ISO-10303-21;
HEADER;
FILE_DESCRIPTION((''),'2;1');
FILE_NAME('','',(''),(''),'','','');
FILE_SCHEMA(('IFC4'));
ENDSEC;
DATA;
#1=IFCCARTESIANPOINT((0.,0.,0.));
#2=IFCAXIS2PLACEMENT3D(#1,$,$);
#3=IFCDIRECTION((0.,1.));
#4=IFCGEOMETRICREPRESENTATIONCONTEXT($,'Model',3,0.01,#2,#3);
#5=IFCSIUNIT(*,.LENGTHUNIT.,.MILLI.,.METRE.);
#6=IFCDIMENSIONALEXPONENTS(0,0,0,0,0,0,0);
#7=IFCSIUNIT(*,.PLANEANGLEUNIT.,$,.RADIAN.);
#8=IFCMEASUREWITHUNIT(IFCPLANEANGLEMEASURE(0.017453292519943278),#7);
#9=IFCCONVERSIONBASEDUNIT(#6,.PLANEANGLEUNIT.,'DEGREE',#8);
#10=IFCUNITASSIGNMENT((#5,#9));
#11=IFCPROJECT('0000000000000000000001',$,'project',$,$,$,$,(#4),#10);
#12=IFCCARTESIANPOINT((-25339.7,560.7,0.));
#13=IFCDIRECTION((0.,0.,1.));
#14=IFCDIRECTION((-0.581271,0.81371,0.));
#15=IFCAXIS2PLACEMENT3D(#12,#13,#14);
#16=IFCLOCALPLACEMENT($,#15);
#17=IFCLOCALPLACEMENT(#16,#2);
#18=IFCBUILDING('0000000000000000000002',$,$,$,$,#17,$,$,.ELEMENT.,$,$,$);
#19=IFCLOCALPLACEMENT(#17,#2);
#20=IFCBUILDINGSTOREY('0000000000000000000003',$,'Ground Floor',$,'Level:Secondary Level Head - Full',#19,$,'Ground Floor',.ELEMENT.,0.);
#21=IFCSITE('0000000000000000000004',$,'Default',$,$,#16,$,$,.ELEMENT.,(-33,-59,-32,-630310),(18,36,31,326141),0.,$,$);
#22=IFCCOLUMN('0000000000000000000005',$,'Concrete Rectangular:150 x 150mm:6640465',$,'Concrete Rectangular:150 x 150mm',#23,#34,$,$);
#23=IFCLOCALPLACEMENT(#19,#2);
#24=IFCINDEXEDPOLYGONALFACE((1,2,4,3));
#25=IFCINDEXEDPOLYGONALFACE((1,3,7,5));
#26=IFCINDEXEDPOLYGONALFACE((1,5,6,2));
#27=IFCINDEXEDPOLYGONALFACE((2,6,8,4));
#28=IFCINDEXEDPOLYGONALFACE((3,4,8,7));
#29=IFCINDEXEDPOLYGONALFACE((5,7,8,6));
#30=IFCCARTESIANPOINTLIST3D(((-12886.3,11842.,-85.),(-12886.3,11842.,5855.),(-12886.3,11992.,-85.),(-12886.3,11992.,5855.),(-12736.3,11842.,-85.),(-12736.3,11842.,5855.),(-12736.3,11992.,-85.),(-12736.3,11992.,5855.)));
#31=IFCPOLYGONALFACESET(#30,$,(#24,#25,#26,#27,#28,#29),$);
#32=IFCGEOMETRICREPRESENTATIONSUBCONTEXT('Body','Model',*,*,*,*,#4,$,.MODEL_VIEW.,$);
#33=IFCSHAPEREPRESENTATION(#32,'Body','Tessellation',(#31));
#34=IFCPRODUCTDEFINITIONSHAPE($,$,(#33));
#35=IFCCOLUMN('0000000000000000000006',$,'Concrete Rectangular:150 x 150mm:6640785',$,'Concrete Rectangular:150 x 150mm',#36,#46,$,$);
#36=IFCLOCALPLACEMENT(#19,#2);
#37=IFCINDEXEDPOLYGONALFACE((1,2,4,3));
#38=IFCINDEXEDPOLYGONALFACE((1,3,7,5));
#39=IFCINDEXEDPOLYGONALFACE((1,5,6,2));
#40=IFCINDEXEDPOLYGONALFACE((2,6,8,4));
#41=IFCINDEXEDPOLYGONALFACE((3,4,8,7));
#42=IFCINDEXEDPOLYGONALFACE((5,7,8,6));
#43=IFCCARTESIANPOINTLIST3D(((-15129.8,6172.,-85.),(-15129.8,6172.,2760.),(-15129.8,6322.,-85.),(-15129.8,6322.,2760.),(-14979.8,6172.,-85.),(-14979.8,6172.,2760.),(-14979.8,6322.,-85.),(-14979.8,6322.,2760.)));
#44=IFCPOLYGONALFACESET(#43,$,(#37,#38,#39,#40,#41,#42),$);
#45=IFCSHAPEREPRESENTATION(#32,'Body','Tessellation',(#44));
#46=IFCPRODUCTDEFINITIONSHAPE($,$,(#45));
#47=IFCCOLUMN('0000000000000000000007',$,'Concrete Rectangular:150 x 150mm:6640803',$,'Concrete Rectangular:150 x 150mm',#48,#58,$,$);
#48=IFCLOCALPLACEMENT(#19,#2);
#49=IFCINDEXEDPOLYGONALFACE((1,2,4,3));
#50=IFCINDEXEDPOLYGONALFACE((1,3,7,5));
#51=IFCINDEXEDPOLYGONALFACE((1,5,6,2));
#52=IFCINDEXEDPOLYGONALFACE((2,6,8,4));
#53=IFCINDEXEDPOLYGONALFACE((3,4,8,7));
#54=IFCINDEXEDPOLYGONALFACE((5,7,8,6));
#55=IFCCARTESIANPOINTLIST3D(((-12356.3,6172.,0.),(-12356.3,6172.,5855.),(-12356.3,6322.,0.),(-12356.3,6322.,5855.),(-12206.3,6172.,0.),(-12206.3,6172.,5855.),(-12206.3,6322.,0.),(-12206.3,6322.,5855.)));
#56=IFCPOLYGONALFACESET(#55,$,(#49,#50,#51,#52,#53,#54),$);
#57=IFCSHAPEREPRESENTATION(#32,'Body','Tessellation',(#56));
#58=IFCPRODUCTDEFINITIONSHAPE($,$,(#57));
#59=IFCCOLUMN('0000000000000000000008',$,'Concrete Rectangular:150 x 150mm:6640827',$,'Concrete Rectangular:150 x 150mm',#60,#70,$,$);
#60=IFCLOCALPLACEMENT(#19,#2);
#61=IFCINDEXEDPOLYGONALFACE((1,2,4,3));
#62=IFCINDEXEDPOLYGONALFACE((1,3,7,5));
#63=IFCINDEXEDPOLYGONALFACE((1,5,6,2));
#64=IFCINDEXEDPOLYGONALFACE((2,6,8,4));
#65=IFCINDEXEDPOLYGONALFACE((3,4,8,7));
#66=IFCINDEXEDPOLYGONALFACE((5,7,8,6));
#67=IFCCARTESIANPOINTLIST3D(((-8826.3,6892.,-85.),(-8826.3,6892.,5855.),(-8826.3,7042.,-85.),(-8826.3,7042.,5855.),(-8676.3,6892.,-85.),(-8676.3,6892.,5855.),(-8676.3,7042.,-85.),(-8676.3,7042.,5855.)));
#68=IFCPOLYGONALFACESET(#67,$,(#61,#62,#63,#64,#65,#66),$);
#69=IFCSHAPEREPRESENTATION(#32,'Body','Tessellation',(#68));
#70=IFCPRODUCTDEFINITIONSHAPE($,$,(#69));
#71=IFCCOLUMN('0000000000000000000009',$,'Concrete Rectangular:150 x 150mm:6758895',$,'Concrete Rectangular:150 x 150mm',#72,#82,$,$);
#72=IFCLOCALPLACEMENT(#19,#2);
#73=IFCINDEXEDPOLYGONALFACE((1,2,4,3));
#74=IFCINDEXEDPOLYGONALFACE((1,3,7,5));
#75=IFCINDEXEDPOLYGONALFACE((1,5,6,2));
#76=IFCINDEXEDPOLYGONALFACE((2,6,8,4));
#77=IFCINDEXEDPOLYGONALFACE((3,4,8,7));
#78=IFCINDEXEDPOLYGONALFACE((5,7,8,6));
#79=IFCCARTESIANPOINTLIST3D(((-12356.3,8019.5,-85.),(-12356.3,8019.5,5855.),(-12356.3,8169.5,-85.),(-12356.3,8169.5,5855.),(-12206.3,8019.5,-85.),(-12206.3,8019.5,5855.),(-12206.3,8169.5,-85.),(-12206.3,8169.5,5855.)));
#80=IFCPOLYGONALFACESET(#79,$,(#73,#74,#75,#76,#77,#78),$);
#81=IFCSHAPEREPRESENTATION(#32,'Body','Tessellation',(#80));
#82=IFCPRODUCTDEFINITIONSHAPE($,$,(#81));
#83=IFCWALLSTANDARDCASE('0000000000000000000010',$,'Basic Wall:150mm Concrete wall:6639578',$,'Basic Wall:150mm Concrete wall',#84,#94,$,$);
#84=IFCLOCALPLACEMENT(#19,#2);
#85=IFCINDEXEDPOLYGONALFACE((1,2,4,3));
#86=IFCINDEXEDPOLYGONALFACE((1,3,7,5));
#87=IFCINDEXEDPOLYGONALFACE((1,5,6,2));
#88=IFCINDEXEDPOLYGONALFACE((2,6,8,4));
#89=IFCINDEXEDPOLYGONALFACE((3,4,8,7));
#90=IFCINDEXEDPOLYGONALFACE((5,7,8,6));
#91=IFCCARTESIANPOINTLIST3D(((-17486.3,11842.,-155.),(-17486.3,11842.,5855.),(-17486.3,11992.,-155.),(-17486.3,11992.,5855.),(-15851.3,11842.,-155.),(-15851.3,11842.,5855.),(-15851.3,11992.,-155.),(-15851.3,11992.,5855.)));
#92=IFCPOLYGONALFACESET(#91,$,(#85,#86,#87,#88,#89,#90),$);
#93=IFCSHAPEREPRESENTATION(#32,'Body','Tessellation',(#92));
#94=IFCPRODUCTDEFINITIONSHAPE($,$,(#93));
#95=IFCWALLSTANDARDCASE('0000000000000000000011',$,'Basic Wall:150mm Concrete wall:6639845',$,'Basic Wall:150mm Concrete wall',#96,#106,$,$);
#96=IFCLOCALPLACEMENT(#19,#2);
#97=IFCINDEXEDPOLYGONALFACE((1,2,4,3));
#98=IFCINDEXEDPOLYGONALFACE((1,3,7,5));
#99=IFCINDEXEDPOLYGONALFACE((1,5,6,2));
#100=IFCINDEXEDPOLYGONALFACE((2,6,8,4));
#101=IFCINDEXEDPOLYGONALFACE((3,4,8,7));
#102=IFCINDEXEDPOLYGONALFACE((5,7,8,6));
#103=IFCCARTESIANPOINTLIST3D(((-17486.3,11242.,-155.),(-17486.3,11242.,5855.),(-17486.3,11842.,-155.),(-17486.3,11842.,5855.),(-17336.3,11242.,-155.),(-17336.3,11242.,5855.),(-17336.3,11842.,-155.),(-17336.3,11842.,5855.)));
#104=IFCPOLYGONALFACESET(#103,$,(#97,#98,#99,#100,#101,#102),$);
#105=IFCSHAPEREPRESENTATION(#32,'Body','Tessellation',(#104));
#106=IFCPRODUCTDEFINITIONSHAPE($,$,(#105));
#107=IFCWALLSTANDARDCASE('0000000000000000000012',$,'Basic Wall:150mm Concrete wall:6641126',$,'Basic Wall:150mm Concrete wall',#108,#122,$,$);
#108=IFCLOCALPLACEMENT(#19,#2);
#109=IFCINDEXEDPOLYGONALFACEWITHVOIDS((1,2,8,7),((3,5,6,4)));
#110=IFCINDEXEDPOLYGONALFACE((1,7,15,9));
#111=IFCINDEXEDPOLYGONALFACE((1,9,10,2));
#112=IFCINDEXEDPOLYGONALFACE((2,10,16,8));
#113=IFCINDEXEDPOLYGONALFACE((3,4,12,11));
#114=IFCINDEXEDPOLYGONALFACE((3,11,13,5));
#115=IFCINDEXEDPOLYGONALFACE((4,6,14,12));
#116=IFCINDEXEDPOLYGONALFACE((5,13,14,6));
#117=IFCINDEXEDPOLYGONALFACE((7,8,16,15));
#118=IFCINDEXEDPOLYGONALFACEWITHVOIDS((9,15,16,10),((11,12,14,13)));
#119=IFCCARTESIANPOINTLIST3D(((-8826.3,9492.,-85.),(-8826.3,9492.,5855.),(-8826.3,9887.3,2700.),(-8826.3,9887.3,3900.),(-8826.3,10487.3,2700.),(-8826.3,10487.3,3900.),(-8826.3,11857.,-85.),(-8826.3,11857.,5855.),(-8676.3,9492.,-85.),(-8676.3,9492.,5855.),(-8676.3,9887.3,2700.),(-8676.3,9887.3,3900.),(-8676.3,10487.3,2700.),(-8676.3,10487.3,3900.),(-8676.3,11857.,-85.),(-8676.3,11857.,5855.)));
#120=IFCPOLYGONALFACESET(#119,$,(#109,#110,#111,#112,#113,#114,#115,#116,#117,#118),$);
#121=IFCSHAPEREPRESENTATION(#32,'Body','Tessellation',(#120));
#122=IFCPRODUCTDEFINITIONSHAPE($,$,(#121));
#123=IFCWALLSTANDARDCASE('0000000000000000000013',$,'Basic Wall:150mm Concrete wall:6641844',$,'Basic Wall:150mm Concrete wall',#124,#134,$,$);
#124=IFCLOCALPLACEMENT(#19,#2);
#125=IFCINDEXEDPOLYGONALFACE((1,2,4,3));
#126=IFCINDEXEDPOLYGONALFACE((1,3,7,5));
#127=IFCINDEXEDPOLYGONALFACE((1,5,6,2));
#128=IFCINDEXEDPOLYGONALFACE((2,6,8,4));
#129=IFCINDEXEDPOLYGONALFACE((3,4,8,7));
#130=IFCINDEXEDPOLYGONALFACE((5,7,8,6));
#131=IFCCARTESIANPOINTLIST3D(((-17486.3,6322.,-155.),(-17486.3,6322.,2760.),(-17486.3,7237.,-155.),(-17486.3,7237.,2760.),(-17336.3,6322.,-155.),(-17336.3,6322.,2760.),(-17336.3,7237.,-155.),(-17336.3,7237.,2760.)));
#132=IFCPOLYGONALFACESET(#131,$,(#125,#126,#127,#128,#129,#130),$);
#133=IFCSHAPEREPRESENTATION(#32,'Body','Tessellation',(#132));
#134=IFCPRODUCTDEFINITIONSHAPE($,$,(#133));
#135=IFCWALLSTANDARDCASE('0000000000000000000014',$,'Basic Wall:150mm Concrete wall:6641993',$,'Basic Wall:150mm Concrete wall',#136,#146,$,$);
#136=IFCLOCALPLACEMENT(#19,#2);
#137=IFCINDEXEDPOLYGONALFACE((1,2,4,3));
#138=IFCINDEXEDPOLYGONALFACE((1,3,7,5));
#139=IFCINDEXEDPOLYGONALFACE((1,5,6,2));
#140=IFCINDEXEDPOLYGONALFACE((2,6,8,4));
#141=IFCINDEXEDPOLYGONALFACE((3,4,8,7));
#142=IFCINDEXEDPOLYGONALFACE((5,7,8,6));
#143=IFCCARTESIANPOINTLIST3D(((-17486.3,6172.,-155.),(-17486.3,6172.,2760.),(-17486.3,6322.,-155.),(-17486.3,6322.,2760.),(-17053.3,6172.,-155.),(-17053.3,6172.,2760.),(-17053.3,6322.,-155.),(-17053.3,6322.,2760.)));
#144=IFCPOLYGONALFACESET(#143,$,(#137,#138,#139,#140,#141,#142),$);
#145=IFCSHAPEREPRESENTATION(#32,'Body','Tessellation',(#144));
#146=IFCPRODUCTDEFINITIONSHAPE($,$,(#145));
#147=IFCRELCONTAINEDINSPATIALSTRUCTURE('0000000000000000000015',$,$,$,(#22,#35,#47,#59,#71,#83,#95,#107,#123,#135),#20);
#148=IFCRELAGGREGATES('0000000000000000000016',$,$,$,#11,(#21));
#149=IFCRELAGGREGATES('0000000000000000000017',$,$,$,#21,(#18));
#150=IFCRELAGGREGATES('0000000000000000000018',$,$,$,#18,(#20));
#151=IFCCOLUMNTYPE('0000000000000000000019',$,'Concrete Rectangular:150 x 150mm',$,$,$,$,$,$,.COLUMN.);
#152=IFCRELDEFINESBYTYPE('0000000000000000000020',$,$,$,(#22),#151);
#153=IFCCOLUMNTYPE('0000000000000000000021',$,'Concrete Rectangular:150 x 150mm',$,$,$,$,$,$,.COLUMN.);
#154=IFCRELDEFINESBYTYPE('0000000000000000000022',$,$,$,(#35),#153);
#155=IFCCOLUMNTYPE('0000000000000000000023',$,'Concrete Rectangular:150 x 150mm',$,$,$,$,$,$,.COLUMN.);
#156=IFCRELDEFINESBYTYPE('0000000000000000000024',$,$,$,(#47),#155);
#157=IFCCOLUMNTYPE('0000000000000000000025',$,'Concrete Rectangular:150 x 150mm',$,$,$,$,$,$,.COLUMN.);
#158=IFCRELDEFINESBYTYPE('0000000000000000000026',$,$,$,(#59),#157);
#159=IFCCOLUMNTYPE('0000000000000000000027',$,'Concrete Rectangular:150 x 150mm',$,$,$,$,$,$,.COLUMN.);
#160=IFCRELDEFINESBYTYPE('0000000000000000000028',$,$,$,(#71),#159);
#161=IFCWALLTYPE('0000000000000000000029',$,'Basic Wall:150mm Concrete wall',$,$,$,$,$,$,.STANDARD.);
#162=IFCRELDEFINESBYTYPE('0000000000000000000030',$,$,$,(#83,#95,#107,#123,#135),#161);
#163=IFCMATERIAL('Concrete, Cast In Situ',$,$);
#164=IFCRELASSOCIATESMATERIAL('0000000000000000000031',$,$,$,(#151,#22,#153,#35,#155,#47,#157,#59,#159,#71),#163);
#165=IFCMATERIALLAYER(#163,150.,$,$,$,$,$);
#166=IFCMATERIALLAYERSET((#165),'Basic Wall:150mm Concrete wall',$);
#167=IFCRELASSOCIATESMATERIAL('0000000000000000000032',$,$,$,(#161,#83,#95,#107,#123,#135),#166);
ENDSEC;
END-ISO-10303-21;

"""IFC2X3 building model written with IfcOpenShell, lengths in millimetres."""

from ifc_helpers import new_model, entity, si_unit, converted_unit, direction, frame, frame_2d, origin, origin_2d_with_axis, place, context, subcontext, project, spatial, polyline, rectangle, extrude, clip, bounded_halfspace, source, transform, mapped, material, layer, layer_set, layer_usage, type_object, type_shapes, element, save


model = new_model("IFC2X3")

# Units and contexts
model_context = context("Model", 3, precision=0.01, world=origin(), true_north=direction((0.0, 1.0)))
body_context = subcontext(model_context, "Body", "Model", "MODEL_VIEW")
ifc_project = project(units=[si_unit("LENGTHUNIT", "METRE", prefix="MILLI"), converted_unit("PLANEANGLEUNIT", "DEGREE", entity("IfcPlaneAngleMeasure", 0.017453292519943278), si_unit("PLANEANGLEUNIT", "RADIAN"), dimensions=[0, 0, 0, 0, 0, 0, 0])], contexts=[model_context])

# Site, building, storey
site_placement = place(None, frame((-25339.7, 560.7, 0.0), z_axis=(0.0, 0.0, 1.0), x_axis=(-0.581271, 0.81371, 0.0)))
site = spatial("IfcSite", under=ifc_project, at=site_placement, Name="Default", CompositionType="ELEMENT", RefLatitude=(-33, -59, -32, -630310), RefLongitude=(18, 36, 31, 326141), RefElevation=0.0)
building_placement = place(site_placement, origin())
building = spatial("IfcBuilding", under=site, at=building_placement, CompositionType="ELEMENT")
storey_placement = place(building_placement, origin())
storey = spatial("IfcBuildingStorey", under=building, at=storey_placement, Name="Ground Floor", ObjectType="Level:Secondary Level Head - Full", LongName="Ground Floor", CompositionType="ELEMENT", Elevation=0.0)

# Columns
ifc_material = material(Name="Concrete, Cast In Situ")
column_type_1 = type_object("IfcColumnType", Name="Concrete Rectangular:150 x 150mm", PredefinedType="COLUMN", material=ifc_material)
shared_shape_1 = source(origin(), body_context, "Body", "SweptSolid", [
    extrude(rectangle(XDim=150.0, YDim=150.0, at=origin_2d_with_axis()), frame((-12811.3, 11917.0, -85.0), z_axis=(0.0, 0.0, 1.0), x_axis=(-1.0, 0.0, 0.0)), (0.0, 0.0, 1.0), 5940.0),
])
type_shapes(column_type_1, [shared_shape_1])
column_1_placement = place(storey_placement, origin())
element("IfcColumn", 1, at=column_1_placement, inside=storey, type_object=column_type_1, material=ifc_material, Name="Concrete Rectangular:150 x 150mm:6640465", ObjectType="Concrete Rectangular:150 x 150mm", context=body_context, shape_type="MappedRepresentation", body=[
    mapped(shared_shape_1, transform((0.0, 0.0, 0.0), scale=1.0)),
])
column_type_2 = type_object("IfcColumnType", Name="Concrete Rectangular:150 x 150mm", PredefinedType="COLUMN", material=ifc_material)
shared_shape_2 = source(origin(), body_context, "Body", "SweptSolid", [
    extrude(rectangle(XDim=150.0, YDim=150.0, at=frame_2d((0.0, 0.0), x_axis=(1.0, 0.0))), frame((-15054.8, 6247.0, -85.0), z_axis=(0.0, 0.0, 1.0), x_axis=(-1.0, 0.0, 0.0)), (0.0, 0.0, 1.0), 2845.0),
])
type_shapes(column_type_2, [shared_shape_2])
column_2_placement = place(storey_placement, origin())
element("IfcColumn", 2, at=column_2_placement, inside=storey, type_object=column_type_2, material=ifc_material, Name="Concrete Rectangular:150 x 150mm:6640785", ObjectType="Concrete Rectangular:150 x 150mm", context=body_context, shape_type="MappedRepresentation", body=[
    mapped(shared_shape_2, transform((0.0, 0.0, 0.0), scale=1.0)),
])
column_type_3 = type_object("IfcColumnType", Name="Concrete Rectangular:150 x 150mm", PredefinedType="COLUMN", material=ifc_material)
shared_shape_3 = source(origin(), body_context, "Body", "SweptSolid", [
    extrude(rectangle(XDim=150.0, YDim=150.0, at=frame_2d((0.0, 0.0), x_axis=(1.0, 0.0))), frame((-12281.3, 6247.0, 0.0), z_axis=(0.0, 0.0, 1.0), x_axis=(-1.0, 0.0, 0.0)), (0.0, 0.0, 1.0), 5855.0),
])
type_shapes(column_type_3, [shared_shape_3])
column_3_placement = place(storey_placement, origin())
element("IfcColumn", 3, at=column_3_placement, inside=storey, type_object=column_type_3, material=ifc_material, Name="Concrete Rectangular:150 x 150mm:6640803", ObjectType="Concrete Rectangular:150 x 150mm", context=body_context, shape_type="MappedRepresentation", body=[
    mapped(shared_shape_3, transform((0.0, 0.0, 0.0), scale=1.0)),
])
column_type_4 = type_object("IfcColumnType", Name="Concrete Rectangular:150 x 150mm", PredefinedType="COLUMN", material=ifc_material)
shared_shape_4 = source(origin(), body_context, "Body", "SweptSolid", [
    extrude(rectangle(XDim=150.0, YDim=150.0, at=frame_2d((0.0, 0.0), x_axis=(1.0, 0.0))), frame((-8751.3, 6967.0, -85.0), z_axis=(0.0, 0.0, 1.0), x_axis=(-1.0, 0.0, 0.0)), (0.0, 0.0, 1.0), 5940.0),
])
type_shapes(column_type_4, [shared_shape_4])
column_4_placement = place(storey_placement, origin())
element("IfcColumn", 4, at=column_4_placement, inside=storey, type_object=column_type_4, material=ifc_material, Name="Concrete Rectangular:150 x 150mm:6640827", ObjectType="Concrete Rectangular:150 x 150mm", context=body_context, shape_type="MappedRepresentation", body=[
    mapped(shared_shape_4, transform((0.0, 0.0, 0.0), scale=1.0)),
])
column_type_5 = type_object("IfcColumnType", Name="Concrete Rectangular:150 x 150mm", PredefinedType="COLUMN", material=ifc_material)
shared_shape_5 = source(origin(), body_context, "Body", "SweptSolid", [
    extrude(rectangle(XDim=150.0, YDim=150.0, at=frame_2d((0.0, 0.0), x_axis=(1.0, 0.0))), frame((-12281.3, 8094.5, -85.0), z_axis=(0.0, 0.0, 1.0), x_axis=(-1.0, 0.0, 0.0)), (0.0, 0.0, 1.0), 5940.0),
])
type_shapes(column_type_5, [shared_shape_5])
column_5_placement = place(storey_placement, origin())
element("IfcColumn", 5, at=column_5_placement, inside=storey, type_object=column_type_5, material=ifc_material, Name="Concrete Rectangular:150 x 150mm:6758895", ObjectType="Concrete Rectangular:150 x 150mm", context=body_context, shape_type="MappedRepresentation", body=[
    mapped(shared_shape_5, transform((0.0, 0.0, 0.0), scale=1.0)),
])

# Walls
ifc_layer_1 = layer(ifc_material, 150.0)
ifc_layer_set_1 = layer_set([ifc_layer_1], Name="Basic Wall:150mm Concrete wall")
ifc_layer_usage_1 = layer_usage(ifc_layer_set_1, "AXIS2", "NEGATIVE", 75.0)
wall_type = type_object("IfcWallType", Name="Basic Wall:150mm Concrete wall", PredefinedType="STANDARD", material=ifc_layer_set_1)
wall_1_placement = place(storey_placement, frame((-15851.3, 11917.0, -155.0), z_axis=(0.0, 0.0, 1.0), x_axis=(-1.0, 0.0, 0.0)))
element("IfcWallStandardCase", 6, at=wall_1_placement, inside=storey, type_object=wall_type, material=ifc_layer_usage_1, Name="Basic Wall:150mm Concrete wall:6639578", ObjectType="Basic Wall:150mm Concrete wall", context=body_context, shape_type="Clipping", body=[
    clip(extrude(rectangle(XDim=1635.0, YDim=150.0, at=frame_2d((817.5, 0.0), x_axis=(-1.0, 0.0))), origin(), (0.0, 0.0, 1.0), 6010.0), bounded_halfspace(frame((0.0, -75.0, 6010.0), z_axis=(0.0, 0.0, 1.0), x_axis=(-1.0, 0.0, 0.0)), False, frame((0.0, -75.0, 6010.0)), polyline([(0.0, 0.0), (1635.0, 0.0), (1635.0, 150.0), (1485.0, 150.0), (0.0, 150.0), (0.0, 0.0)]))),
])
ifc_layer_usage_2 = layer_usage(ifc_layer_set_1, "AXIS2", "NEGATIVE", 75.0)
wall_2_placement = place(storey_placement, frame((-17411.3, 11842.0, -155.0), z_axis=(0.0, 0.0, 1.0), x_axis=(0.0, -1.0, 0.0)))
element("IfcWallStandardCase", 7, at=wall_2_placement, inside=storey, type_object=wall_type, material=ifc_layer_usage_2, Name="Basic Wall:150mm Concrete wall:6639845", ObjectType="Basic Wall:150mm Concrete wall", context=body_context, shape_type="Clipping", body=[
    clip(extrude(rectangle(XDim=600.0, YDim=150.0, at=frame_2d((300.0, 0.0), x_axis=(-1.0, 0.0))), origin(), (0.0, 0.0, 1.0), 6010.0), bounded_halfspace(frame((0.0, -75.0, 6010.0), z_axis=(0.0, 0.0, 1.0), x_axis=(0.0, 1.0, 0.0)), False, frame((0.0, -75.0, 6010.0)), polyline([(0.0, 0.0), (600.0, 0.0), (600.0, 150.0), (0.0, 150.0), (0.0, 0.0)]))),
])

# Wall, opening
ifc_layer_usage_3 = layer_usage(ifc_layer_set_1, "AXIS2", "POSITIVE", -75.0)
wall_3_placement = place(storey_placement, frame((-8751.3, 11857.0, -85.0), z_axis=(0.0, 0.0, 1.0), x_axis=(0.0, -1.0, 0.0)))
wall_3 = element("IfcWallStandardCase", 8, at=wall_3_placement, inside=storey, type_object=wall_type, material=ifc_layer_usage_3, Name="Basic Wall:150mm Concrete wall:6641126", ObjectType="Basic Wall:150mm Concrete wall", context=body_context, shape_type="Clipping", body=[
    clip(extrude(rectangle(XDim=2365.0, YDim=150.0, at=frame_2d((1182.5, 0.0), x_axis=(-1.0, 0.0))), origin(), (0.0, 0.0, 1.0), 5940.0), bounded_halfspace(frame((0.0, -75.0, 5940.0), z_axis=(0.0, 0.0, 1.0), x_axis=(0.0, 1.0, 0.0)), False, frame((0.0, -75.0, 5940.0)), polyline([(0.0, 0.0), (2365.0, 0.0), (2365.0, 150.0), (0.0, 150.0), (0.0, 0.0)]))),
])
opening_1_placement = place(wall_3_placement, origin())
element("IfcOpeningElement", 9, at=opening_1_placement, cuts=wall_3, ObjectType="Opening", context=body_context, shape_type="SweptSolid", body=[
    extrude(rectangle(XDim=1200.0, YDim=600.0, at=frame_2d((0.0, 0.0), x_axis=(1.0, 0.0))), frame((1669.8, -75.0, 3385.0), z_axis=(0.0, 1.0, 0.0), x_axis=(0.0, 0.0, -1.0)), (0.0, 0.0, 1.0), 150.0),
])

# Walls
ifc_layer_usage_4 = layer_usage(ifc_layer_set_1, "AXIS2", "POSITIVE", -75.0)
wall_4_placement = place(storey_placement, frame((-17411.3, 7237.0, -155.0), z_axis=(0.0, 0.0, 1.0), x_axis=(0.0, -1.0, 0.0)))
element("IfcWallStandardCase", 10, at=wall_4_placement, inside=storey, type_object=wall_type, material=ifc_layer_usage_4, Name="Basic Wall:150mm Concrete wall:6641844", ObjectType="Basic Wall:150mm Concrete wall", context=body_context, shape_type="Clipping", body=[
    clip(extrude(rectangle(XDim=915.0, YDim=150.0, at=frame_2d((457.5, 0.0), x_axis=(-1.0, 0.0))), origin(), (0.0, 0.0, 1.0), 2915.0), bounded_halfspace(frame((0.0, -75.0, 2915.0), z_axis=(0.0, 0.0, -1.0), x_axis=(0.0, 1.0, 0.0)), True, frame((0.0, -75.0, 2915.0)), polyline([(0.0, 0.0), (915.0, 0.0), (915.0, 150.0), (0.0, 150.0), (0.0, 0.0)]))),
])
ifc_layer_usage_5 = layer_usage(ifc_layer_set_1, "AXIS2", "POSITIVE", -75.0)
wall_5_placement = place(storey_placement, frame((-17486.3, 6247.0, -155.0)))
element("IfcWallStandardCase", 11, at=wall_5_placement, inside=storey, type_object=wall_type, material=ifc_layer_usage_5, Name="Basic Wall:150mm Concrete wall:6641993", ObjectType="Basic Wall:150mm Concrete wall", context=body_context, shape_type="Clipping", body=[
    clip(extrude(rectangle(XDim=433.0, YDim=150.0, at=frame_2d((216.5, 0.0), x_axis=(-1.0, 0.0))), origin(), (0.0, 0.0, 1.0), 2915.0), bounded_halfspace(frame((0.0, -75.0, 2915.0), z_axis=(0.0, 0.0, -1.0), x_axis=(1.0, 0.0, 0.0)), True, frame((0.0, -75.0, 2915.0)), polyline([(0.0, 0.0), (433.0, 0.0), (433.0, 150.0), (150.0, 150.0), (0.0, 150.0), (0.0, 0.0)]))),
])

save(model, "model.ifc")
